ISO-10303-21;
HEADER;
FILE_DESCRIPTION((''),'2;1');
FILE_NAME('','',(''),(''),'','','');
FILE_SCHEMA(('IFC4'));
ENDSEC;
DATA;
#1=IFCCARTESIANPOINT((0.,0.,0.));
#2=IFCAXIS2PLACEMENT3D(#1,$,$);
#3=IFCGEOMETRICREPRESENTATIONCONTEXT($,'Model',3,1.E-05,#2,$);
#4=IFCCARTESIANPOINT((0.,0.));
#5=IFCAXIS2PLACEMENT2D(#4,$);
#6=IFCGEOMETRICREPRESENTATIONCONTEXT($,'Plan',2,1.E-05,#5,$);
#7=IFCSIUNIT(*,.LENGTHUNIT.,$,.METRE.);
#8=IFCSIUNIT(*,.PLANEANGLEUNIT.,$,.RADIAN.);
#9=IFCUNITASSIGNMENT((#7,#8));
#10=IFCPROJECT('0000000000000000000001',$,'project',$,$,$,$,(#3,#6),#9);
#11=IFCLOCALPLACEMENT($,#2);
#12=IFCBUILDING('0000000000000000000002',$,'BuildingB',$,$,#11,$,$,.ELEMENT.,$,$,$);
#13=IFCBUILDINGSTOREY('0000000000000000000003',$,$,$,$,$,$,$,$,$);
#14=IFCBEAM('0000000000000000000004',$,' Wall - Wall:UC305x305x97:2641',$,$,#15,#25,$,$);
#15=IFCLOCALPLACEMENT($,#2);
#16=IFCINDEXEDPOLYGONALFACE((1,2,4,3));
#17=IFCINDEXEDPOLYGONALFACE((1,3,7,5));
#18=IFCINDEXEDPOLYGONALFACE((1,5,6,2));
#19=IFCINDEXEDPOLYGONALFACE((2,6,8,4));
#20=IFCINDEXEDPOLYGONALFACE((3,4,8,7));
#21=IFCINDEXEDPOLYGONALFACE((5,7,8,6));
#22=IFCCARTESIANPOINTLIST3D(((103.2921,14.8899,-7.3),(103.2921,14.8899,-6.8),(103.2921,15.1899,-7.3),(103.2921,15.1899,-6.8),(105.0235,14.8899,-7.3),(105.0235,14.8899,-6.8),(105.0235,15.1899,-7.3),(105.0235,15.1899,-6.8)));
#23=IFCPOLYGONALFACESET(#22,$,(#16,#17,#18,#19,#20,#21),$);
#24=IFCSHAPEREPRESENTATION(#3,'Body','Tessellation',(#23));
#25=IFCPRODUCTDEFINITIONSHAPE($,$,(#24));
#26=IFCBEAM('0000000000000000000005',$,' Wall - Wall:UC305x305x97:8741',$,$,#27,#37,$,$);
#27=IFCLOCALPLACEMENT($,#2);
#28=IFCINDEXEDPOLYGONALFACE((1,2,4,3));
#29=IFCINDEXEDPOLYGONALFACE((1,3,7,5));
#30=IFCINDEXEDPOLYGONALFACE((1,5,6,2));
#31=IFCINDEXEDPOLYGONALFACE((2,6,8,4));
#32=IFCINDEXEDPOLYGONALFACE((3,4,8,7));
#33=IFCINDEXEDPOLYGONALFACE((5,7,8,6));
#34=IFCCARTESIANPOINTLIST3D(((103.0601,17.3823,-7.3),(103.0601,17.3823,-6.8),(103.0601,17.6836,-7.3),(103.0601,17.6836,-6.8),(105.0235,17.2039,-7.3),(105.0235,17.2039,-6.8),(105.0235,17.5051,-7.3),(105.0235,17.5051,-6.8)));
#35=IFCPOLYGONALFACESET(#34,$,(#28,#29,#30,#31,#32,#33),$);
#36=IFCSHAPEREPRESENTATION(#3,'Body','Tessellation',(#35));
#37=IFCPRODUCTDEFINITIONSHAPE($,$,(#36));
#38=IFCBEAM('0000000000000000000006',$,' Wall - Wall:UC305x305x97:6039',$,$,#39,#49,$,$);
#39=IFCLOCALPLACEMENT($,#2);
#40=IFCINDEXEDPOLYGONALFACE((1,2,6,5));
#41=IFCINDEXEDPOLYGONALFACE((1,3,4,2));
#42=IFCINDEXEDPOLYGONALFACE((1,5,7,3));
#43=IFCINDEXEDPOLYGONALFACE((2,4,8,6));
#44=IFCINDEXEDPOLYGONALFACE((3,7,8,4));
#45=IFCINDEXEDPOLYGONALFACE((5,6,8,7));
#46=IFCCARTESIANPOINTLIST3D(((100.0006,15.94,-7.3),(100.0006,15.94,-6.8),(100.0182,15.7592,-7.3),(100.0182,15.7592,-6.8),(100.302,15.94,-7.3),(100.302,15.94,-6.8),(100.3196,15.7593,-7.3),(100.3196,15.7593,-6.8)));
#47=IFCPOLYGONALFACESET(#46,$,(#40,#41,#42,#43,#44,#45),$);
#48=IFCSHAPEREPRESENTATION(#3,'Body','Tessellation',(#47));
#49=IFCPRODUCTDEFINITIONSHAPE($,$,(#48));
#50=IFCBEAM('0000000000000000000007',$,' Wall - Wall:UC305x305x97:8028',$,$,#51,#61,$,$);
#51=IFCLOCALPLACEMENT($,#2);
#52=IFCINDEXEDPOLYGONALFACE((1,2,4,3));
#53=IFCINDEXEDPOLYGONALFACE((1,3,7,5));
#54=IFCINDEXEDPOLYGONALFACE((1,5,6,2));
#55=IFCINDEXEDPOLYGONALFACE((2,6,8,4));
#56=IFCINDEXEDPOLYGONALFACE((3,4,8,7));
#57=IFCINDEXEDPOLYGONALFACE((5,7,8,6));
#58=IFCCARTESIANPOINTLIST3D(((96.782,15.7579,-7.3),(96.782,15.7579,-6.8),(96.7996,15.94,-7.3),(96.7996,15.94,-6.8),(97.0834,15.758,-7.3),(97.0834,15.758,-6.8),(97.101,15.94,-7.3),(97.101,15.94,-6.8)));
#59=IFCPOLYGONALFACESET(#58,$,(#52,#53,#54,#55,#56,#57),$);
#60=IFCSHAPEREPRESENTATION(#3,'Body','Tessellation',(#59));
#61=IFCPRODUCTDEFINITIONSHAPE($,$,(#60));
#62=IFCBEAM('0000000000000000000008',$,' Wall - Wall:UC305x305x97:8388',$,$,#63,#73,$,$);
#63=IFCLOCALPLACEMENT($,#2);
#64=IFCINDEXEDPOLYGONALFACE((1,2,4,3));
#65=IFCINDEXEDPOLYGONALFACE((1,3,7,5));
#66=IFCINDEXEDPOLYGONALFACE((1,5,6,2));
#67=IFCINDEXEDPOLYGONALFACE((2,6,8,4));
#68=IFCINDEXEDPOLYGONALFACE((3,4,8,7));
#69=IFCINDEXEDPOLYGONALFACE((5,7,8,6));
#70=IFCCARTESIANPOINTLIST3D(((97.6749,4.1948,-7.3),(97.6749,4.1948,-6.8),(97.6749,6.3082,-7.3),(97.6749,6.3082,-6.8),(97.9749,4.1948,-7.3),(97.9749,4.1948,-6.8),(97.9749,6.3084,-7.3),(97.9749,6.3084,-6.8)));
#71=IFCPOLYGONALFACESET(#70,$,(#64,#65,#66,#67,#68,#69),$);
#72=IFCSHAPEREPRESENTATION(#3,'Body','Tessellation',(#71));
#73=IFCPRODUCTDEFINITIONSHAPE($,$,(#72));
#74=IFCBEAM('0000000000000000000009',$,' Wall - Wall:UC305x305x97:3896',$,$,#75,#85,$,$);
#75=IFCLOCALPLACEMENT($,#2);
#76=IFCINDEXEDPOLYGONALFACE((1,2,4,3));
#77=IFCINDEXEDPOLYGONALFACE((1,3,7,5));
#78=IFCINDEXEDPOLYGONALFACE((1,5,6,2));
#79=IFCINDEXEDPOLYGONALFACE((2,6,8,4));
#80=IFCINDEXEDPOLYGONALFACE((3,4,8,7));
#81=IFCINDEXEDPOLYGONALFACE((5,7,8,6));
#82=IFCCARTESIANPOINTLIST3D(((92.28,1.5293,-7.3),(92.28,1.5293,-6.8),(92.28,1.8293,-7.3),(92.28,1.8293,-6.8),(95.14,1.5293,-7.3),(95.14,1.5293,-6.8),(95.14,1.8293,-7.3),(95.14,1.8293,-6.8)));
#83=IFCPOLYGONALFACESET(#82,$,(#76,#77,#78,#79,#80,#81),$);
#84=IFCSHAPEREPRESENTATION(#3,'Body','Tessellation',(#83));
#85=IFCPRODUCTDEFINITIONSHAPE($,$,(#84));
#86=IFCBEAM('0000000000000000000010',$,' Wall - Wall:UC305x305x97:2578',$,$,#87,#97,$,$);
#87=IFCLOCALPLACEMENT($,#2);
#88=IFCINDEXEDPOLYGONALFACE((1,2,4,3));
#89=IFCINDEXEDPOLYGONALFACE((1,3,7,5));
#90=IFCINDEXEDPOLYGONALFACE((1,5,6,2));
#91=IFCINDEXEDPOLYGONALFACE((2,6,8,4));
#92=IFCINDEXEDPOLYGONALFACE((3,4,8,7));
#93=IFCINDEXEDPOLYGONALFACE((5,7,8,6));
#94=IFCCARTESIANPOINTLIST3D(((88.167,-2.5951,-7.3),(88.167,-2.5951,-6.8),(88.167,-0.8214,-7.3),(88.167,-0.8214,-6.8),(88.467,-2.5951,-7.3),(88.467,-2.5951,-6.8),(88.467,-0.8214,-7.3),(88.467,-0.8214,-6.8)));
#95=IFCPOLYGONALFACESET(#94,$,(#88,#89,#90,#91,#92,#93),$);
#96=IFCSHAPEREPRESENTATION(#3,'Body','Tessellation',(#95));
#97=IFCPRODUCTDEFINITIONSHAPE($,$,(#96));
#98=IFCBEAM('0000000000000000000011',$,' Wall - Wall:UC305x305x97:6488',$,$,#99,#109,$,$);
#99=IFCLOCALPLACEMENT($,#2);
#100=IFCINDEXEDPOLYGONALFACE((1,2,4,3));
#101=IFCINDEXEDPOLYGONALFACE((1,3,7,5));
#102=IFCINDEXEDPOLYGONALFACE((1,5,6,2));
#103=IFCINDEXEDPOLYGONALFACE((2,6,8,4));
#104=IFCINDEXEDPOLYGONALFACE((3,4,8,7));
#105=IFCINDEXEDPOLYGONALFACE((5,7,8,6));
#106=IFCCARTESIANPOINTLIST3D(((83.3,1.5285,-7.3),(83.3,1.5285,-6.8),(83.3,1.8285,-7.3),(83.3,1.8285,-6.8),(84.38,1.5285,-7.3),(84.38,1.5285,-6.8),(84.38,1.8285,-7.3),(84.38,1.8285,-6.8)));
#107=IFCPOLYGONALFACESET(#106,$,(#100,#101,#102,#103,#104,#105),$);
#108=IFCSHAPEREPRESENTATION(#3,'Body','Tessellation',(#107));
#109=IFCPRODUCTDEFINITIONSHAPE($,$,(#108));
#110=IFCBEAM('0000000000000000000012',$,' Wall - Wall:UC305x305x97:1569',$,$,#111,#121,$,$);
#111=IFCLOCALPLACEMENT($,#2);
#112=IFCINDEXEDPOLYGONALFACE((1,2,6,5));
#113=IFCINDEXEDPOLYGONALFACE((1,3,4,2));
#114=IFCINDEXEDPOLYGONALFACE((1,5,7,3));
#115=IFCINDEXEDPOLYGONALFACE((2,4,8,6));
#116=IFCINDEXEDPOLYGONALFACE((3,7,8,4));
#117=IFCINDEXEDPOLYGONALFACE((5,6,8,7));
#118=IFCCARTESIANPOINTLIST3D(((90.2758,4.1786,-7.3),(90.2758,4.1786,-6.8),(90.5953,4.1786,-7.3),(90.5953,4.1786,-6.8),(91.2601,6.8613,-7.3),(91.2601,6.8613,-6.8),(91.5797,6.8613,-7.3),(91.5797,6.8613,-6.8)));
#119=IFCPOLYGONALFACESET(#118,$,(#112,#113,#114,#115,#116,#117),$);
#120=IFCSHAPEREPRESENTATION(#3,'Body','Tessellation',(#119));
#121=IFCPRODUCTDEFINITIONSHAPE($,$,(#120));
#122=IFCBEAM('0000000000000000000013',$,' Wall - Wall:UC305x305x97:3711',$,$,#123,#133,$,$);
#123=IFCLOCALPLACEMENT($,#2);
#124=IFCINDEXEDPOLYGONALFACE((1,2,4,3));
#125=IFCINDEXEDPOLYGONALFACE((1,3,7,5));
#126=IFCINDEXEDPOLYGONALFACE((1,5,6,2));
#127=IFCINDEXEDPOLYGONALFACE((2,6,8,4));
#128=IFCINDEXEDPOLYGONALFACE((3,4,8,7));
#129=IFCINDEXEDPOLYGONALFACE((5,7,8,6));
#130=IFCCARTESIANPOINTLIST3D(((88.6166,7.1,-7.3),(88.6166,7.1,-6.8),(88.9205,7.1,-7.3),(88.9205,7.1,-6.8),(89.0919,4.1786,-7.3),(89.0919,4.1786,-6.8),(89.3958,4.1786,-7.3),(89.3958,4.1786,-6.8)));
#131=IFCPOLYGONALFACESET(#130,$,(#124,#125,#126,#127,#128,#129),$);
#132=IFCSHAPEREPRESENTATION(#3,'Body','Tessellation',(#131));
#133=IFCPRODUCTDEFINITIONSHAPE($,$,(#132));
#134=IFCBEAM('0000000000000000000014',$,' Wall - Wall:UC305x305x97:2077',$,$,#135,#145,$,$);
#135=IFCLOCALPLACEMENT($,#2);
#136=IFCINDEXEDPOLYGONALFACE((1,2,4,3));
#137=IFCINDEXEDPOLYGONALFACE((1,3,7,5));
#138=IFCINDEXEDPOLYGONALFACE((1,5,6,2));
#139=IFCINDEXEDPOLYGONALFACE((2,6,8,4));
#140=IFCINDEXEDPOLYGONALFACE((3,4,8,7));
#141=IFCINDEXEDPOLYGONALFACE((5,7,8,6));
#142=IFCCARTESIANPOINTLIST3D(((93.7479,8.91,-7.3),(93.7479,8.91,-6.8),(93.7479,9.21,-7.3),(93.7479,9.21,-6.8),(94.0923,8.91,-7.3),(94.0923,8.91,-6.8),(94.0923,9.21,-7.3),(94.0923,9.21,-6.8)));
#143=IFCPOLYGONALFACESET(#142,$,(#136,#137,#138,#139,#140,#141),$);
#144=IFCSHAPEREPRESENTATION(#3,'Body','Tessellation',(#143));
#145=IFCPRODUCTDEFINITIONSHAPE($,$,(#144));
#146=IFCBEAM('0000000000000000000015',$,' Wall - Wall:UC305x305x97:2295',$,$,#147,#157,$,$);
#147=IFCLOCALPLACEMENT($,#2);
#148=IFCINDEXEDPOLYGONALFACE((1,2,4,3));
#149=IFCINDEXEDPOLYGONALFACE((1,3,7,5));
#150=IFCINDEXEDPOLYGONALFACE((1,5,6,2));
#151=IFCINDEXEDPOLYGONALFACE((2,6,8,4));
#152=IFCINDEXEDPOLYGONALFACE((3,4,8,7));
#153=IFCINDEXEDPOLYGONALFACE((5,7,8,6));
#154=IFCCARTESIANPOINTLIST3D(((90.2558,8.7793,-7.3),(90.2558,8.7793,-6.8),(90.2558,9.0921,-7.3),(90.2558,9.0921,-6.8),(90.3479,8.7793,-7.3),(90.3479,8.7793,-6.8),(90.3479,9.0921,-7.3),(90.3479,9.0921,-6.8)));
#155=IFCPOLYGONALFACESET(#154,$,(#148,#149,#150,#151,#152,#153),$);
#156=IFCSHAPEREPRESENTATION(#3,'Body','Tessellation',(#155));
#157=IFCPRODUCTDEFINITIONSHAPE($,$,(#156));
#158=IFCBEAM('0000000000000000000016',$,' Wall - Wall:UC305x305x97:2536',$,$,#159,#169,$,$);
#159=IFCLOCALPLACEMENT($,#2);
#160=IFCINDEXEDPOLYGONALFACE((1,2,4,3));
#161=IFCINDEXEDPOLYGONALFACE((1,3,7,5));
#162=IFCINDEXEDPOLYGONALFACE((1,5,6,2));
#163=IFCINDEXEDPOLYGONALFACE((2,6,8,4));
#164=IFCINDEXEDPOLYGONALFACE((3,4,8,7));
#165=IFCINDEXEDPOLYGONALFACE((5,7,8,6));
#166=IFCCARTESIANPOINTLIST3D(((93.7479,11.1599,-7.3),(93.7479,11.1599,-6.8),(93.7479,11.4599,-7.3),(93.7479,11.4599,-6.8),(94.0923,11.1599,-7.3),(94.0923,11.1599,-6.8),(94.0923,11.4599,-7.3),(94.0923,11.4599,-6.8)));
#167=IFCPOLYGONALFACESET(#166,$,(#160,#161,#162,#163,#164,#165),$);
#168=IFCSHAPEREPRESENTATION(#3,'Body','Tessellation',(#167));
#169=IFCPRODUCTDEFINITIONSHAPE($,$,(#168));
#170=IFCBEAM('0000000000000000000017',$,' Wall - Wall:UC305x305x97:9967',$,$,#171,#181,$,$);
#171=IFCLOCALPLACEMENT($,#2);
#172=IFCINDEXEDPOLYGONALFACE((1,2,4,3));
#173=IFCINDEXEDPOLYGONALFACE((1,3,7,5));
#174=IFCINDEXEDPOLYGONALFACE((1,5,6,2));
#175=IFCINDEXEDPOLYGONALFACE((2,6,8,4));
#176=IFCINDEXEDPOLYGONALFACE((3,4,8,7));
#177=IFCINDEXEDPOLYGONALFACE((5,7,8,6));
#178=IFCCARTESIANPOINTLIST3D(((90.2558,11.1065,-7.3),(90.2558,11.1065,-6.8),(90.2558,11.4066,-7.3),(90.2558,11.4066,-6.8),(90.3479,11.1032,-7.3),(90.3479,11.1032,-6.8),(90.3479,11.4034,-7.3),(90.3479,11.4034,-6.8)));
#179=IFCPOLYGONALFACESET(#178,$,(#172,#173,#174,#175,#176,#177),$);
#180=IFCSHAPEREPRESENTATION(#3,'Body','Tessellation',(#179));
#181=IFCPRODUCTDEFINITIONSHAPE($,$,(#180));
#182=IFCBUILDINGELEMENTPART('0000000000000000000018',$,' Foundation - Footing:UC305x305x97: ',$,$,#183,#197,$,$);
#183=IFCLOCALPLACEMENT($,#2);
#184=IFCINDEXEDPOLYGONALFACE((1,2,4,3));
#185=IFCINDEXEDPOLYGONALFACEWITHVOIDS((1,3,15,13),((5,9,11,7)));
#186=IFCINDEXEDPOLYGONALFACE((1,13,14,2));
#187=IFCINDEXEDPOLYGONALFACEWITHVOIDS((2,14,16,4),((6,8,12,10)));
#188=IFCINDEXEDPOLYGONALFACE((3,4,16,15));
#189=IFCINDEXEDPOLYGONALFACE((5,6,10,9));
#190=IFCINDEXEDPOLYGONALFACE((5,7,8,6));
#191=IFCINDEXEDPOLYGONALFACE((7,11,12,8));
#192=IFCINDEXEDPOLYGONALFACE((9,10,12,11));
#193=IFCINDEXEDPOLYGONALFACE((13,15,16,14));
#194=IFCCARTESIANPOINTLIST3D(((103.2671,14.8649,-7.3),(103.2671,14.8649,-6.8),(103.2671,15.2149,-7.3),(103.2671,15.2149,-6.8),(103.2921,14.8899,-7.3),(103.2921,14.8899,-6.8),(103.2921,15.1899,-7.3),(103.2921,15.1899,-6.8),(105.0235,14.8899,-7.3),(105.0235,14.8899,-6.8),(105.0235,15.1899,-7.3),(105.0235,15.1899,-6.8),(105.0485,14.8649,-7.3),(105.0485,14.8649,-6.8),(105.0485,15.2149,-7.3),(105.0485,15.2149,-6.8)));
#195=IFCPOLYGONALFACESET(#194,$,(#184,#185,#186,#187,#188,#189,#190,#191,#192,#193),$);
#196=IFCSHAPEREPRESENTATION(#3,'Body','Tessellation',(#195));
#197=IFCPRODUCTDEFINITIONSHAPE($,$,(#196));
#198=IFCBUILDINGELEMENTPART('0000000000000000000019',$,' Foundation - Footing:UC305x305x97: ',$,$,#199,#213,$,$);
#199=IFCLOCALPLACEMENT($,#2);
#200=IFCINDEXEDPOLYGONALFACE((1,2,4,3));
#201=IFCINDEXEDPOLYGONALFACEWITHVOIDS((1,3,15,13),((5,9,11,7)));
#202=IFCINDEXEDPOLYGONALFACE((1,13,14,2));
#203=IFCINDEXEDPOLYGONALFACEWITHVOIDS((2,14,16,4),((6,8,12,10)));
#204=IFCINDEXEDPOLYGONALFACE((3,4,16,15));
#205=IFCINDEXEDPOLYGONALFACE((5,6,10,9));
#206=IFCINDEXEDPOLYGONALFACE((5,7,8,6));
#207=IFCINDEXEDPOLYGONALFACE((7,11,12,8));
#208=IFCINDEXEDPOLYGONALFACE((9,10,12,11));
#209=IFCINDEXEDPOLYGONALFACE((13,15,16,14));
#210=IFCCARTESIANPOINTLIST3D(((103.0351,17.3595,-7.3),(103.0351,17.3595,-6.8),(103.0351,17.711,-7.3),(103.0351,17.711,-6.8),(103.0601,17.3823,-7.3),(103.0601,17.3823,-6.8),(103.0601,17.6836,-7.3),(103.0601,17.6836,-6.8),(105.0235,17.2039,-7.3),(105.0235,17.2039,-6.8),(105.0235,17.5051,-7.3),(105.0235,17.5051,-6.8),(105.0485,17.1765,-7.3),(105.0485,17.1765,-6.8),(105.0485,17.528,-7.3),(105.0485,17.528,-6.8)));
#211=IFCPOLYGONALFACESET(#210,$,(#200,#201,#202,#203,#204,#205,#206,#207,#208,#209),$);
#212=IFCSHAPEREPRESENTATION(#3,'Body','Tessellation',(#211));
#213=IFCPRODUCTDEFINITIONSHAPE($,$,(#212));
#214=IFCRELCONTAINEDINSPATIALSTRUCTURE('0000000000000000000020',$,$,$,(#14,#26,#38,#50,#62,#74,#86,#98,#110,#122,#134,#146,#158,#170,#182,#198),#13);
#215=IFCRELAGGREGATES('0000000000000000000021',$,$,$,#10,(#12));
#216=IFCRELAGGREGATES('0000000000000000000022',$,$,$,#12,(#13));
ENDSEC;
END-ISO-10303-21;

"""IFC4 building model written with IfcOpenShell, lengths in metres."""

from ifc_helpers import new_model, si_unit, origin, origin_2d, place, context, project, spatial, polyline, outline, extrude, element, save


model = new_model("IFC4")

# Units and contexts
model_context = context("Model", 3, precision=1e-05, world=origin())
plan_context = context("Plan", 2, precision=1e-05, world=origin_2d())
ifc_project = project(units=[si_unit("LENGTHUNIT", "METRE"), si_unit("PLANEANGLEUNIT", "RADIAN")], contexts=[model_context, plan_context])

# Building, storey
building_placement = place(None, origin())
building = spatial("IfcBuilding", under=ifc_project, at=building_placement, Name="BuildingB", CompositionType="ELEMENT")
storey = spatial("IfcBuildingStorey", under=building)

# Beams
element("IfcBeam", 1, inside=storey, Name=" Wall - Wall:UC305x305x97:2641", context=model_context, shape_type="SweptSolid", body=[
    extrude(outline(polyline([(105.0235, 14.8899, -7.3), (105.0235, 15.1899, -7.3), (103.2921, 15.1899, -7.3), (103.2921, 14.8899, -7.3), (105.0235, 14.8899, -7.3)])), None, (0.0, 0.0, 1.0), 0.5),
])
element("IfcBeam", 2, inside=storey, Name=" Wall - Wall:UC305x305x97:8741", context=model_context, shape_type="SweptSolid", body=[
    extrude(outline(polyline([(105.0235, 17.2039, -7.3), (105.0235, 17.5051, -7.3), (103.0601, 17.6836, -7.3), (103.0601, 17.3823, -7.3), (105.0235, 17.2039, -7.3)])), None, (0.0, 0.0, 1.0), 0.5),
])
element("IfcBeam", 3, inside=storey, Name=" Wall - Wall:UC305x305x97:6039", context=model_context, shape_type="SweptSolid", body=[
    extrude(outline(polyline([(100.3196, 15.7593, -7.3), (100.302, 15.94, -7.3), (100.0006, 15.94, -7.3), (100.0182, 15.7592, -7.3), (100.3196, 15.7593, -7.3)])), None, (0.0, 0.0, 1.0), 0.5),
])
element("IfcBeam", 4, inside=storey, Name=" Wall - Wall:UC305x305x97:8028", context=model_context, shape_type="SweptSolid", body=[
    extrude(outline(polyline([(97.0834, 15.758, -7.3), (97.101, 15.94, -7.3), (96.7996, 15.94, -7.3), (96.782, 15.7579, -7.3), (97.0834, 15.758, -7.3)])), None, (0.0, 0.0, 1.0), 0.5),
])
element("IfcBeam", 5, inside=storey, Name=" Wall - Wall:UC305x305x97:8388", context=model_context, shape_type="SweptSolid", body=[
    extrude(outline(polyline([(97.9749, 4.1948, -7.3), (97.9749, 6.3084, -7.3), (97.6749, 6.3082, -7.3), (97.6749, 4.1948, -7.3), (97.9749, 4.1948, -7.3)])), None, (0.0, 0.0, 1.0), 0.5),
])
element("IfcBeam", 6, inside=storey, Name=" Wall - Wall:UC305x305x97:3896", context=model_context, shape_type="SweptSolid", body=[
    extrude(outline(polyline([(95.14, 1.5293, -7.3), (95.14, 1.8293, -7.3), (92.28, 1.8293, -7.3), (92.28, 1.5293, -7.3), (95.14, 1.5293, -7.3)])), None, (0.0, 0.0, 1.0), 0.5),
])
element("IfcBeam", 7, inside=storey, Name=" Wall - Wall:UC305x305x97:2578", context=model_context, shape_type="SweptSolid", body=[
    extrude(outline(polyline([(88.467, -2.5951, -7.3), (88.467, -0.8214, -7.3), (88.167, -0.8214, -7.3), (88.167, -2.5951, -7.3), (88.467, -2.5951, -7.3)])), None, (0.0, 0.0, 1.0), 0.5),
])
element("IfcBeam", 8, inside=storey, Name=" Wall - Wall:UC305x305x97:6488", context=model_context, shape_type="SweptSolid", body=[
    extrude(outline(polyline([(84.38, 1.5285, -7.3), (84.38, 1.8285, -7.3), (83.3, 1.8285, -7.3), (83.3, 1.5285, -7.3), (84.38, 1.5285, -7.3)])), None, (0.0, 0.0, 1.0), 0.5),
])
element("IfcBeam", 9, inside=storey, Name=" Wall - Wall:UC305x305x97:1569", context=model_context, shape_type="SweptSolid", body=[
    extrude(outline(polyline([(90.5953, 4.1786, -7.3), (90.2758, 4.1786, -7.3), (91.2601, 6.8613, -7.3), (91.5797, 6.8613, -7.3), (90.5953, 4.1786, -7.3)])), None, (0.0, 0.0, 1.0), 0.5),
])
element("IfcBeam", 10, inside=storey, Name=" Wall - Wall:UC305x305x97:3711", context=model_context, shape_type="SweptSolid", body=[
    extrude(outline(polyline([(89.3958, 4.1786, -7.3), (89.0919, 4.1786, -7.3), (88.6166, 7.1, -7.3), (88.9205, 7.1, -7.3), (89.3958, 4.1786, -7.3)])), None, (0.0, 0.0, 1.0), 0.5),
])
element("IfcBeam", 11, inside=storey, Name=" Wall - Wall:UC305x305x97:2077", context=model_context, shape_type="SweptSolid", body=[
    extrude(outline(polyline([(94.0923, 8.91, -7.3), (94.0923, 9.21, -7.3), (93.7479, 9.21, -7.3), (93.7479, 8.91, -7.3), (94.0923, 8.91, -7.3)])), None, (0.0, 0.0, 1.0), 0.5),
])
element("IfcBeam", 12, inside=storey, Name=" Wall - Wall:UC305x305x97:2295", context=model_context, shape_type="SweptSolid", body=[
    extrude(outline(polyline([(90.3479, 8.7793, -7.3), (90.2558, 8.7793, -7.3), (90.2558, 9.0921, -7.3), (90.3479, 9.0921, -7.3), (90.3479, 8.7793, -7.3)])), None, (0.0, 0.0, 1.0), 0.5),
])
element("IfcBeam", 13, inside=storey, Name=" Wall - Wall:UC305x305x97:2536", context=model_context, shape_type="SweptSolid", body=[
    extrude(outline(polyline([(94.0923, 11.1599, -7.3), (93.7479, 11.1599, -7.3), (93.7479, 11.4599, -7.3), (94.0923, 11.4599, -7.3), (94.0923, 11.1599, -7.3)])), None, (0.0, 0.0, 1.0), 0.5),
])
element("IfcBeam", 14, inside=storey, Name=" Wall - Wall:UC305x305x97:9967", context=model_context, shape_type="SweptSolid", body=[
    extrude(outline(polyline([(90.3479, 11.1032, -7.3), (90.2558, 11.1065, -7.3), (90.2558, 11.4066, -7.3), (90.3479, 11.4034, -7.3), (90.3479, 11.1032, -7.3)])), None, (0.0, 0.0, 1.0), 0.5),
])

# Building element parts, openings
building_element_part_1 = element("IfcBuildingElementPart", 15, inside=storey, Name=" Foundation - Footing:UC305x305x97: ", context=model_context, shape_type="SweptSolid", body=[
    extrude(outline(polyline([(105.0485, 14.8649, -7.3), (105.0485, 15.2149, -7.3), (103.2671, 15.2149, -7.3), (103.2671, 14.8649, -7.3), (105.0485, 14.8649, -7.3)])), None, (0.0, 0.0, 1.0), 0.5),
])
element("IfcOpeningElement", 16, inside=storey, cuts=building_element_part_1, context=model_context, shape_type="SweptSolid", body=[
    extrude(outline(polyline([(105.0235, 14.8899, -7.3), (105.0235, 15.1899, -7.3), (103.2921, 15.1899, -7.3), (103.2921, 14.8899, -7.3), (105.0235, 14.8899, -7.3)])), None, (0.0, 0.0, 1.0), 0.5),
])
building_element_part_2 = element("IfcBuildingElementPart", 17, inside=storey, Name=" Foundation - Footing:UC305x305x97: ", context=model_context, shape_type="SweptSolid", body=[
    extrude(outline(polyline([(105.0485, 17.1765, -7.3), (105.0485, 17.528, -7.3), (103.0351, 17.711, -7.3), (103.0351, 17.3595, -7.3), (105.0485, 17.1765, -7.3)])), None, (0.0, 0.0, 1.0), 0.5),
])
element("IfcOpeningElement", 18, inside=storey, cuts=building_element_part_2, context=model_context, shape_type="SweptSolid", body=[
    extrude(outline(polyline([(105.0235, 17.2039, -7.3), (105.0235, 17.5051, -7.3), (103.0601, 17.6836, -7.3), (103.0601, 17.3823, -7.3), (105.0235, 17.2039, -7.3)])), None, (0.0, 0.0, 1.0), 0.5),
])

save(model, "model.ifc")
